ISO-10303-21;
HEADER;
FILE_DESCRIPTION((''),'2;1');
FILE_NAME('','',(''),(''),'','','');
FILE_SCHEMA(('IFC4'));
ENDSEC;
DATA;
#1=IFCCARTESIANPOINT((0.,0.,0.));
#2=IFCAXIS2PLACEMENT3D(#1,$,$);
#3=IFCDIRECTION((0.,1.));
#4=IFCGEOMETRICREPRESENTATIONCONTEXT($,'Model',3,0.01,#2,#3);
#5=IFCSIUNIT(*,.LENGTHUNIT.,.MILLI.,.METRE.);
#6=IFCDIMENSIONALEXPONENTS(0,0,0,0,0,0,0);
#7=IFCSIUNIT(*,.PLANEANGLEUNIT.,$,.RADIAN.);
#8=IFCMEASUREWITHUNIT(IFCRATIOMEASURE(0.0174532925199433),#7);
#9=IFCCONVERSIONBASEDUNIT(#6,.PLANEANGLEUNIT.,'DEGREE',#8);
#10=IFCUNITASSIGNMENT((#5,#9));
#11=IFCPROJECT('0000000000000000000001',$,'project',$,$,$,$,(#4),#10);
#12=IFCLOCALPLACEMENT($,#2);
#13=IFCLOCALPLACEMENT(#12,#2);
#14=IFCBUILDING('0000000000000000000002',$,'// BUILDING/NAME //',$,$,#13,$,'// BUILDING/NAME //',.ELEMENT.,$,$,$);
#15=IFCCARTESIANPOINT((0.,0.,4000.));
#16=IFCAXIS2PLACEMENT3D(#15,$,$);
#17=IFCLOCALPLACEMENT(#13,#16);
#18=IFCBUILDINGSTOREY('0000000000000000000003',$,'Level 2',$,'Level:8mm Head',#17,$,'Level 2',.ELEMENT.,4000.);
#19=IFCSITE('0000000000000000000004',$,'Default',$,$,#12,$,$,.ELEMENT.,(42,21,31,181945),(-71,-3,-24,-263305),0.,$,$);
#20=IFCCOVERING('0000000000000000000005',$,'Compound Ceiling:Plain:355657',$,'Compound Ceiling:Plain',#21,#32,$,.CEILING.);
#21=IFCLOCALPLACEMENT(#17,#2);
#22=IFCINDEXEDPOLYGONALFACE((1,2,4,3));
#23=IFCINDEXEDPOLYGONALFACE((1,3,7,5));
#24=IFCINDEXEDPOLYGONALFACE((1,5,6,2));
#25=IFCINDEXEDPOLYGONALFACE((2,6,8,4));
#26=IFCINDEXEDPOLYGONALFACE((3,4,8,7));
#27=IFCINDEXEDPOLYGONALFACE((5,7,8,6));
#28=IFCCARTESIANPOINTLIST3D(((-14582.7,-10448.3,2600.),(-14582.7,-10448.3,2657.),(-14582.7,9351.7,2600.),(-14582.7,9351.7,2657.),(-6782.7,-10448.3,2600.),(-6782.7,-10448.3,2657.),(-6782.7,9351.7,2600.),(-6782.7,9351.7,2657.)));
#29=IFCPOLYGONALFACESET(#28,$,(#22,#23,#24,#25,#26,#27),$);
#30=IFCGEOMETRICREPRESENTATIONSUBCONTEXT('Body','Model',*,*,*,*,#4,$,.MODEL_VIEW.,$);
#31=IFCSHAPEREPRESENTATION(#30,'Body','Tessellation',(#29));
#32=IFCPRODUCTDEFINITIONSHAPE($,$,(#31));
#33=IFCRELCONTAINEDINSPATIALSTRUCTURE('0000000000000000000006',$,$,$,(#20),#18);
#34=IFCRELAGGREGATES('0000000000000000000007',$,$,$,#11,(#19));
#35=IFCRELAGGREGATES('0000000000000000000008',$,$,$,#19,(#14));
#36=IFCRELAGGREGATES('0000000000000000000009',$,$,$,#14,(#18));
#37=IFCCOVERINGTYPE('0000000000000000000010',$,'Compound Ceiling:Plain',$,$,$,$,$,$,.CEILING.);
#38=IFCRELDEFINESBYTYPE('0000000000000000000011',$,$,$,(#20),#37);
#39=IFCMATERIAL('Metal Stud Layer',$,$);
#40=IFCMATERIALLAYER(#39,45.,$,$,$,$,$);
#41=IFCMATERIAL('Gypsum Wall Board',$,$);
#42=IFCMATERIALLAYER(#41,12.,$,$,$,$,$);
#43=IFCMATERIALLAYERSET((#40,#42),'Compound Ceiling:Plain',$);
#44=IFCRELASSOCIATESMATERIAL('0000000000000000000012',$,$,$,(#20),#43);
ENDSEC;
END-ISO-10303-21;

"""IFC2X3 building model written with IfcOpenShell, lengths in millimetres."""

from ifc_helpers import new_model, entity, si_unit, converted_unit, direction, frame, frame_2d, origin, place, context, subcontext, project, spatial, rectangle, extrude, material, layer, layer_set, layer_usage, type_object, element, save


model = new_model("IFC2X3")

# Units and contexts
model_context = context("Model", 3, precision=0.01, world=origin(), true_north=direction((0.0, 1.0)))
body_context = subcontext(model_context, "Body", "Model", "MODEL_VIEW")
ifc_project = project(units=[si_unit("LENGTHUNIT", "METRE", prefix="MILLI"), converted_unit("PLANEANGLEUNIT", "DEGREE", entity("IfcRatioMeasure", 0.0174532925199433), si_unit("PLANEANGLEUNIT", "RADIAN"), dimensions=[0, 0, 0, 0, 0, 0, 0])], contexts=[model_context])

# Site, building, storey
site_placement = place(None, origin())
site = spatial("IfcSite", under=ifc_project, at=site_placement, Name="Default", CompositionType="ELEMENT", RefLatitude=(42, 21, 31, 181945), RefLongitude=(-71, -3, -24, -263305), RefElevation=0.0)
building_placement = place(site_placement, origin())
building = spatial("IfcBuilding", under=site, at=building_placement, Name="// BUILDING/NAME //", LongName="// BUILDING/NAME //", CompositionType="ELEMENT")
storey_placement = place(building_placement, frame((0.0, 0.0, 4000.0)))
storey = spatial("IfcBuildingStorey", under=building, at=storey_placement, Name="Level 2", ObjectType="Level:8mm Head", LongName="Level 2", CompositionType="ELEMENT", Elevation=4000.0)

# Covering
ifc_material_1 = material(Name="Metal Stud Layer")
ifc_layer_1 = layer(ifc_material_1, 45.0)
ifc_material_2 = material(Name="Gypsum Wall Board")
ifc_layer_2 = layer(ifc_material_2, 12.0)
ifc_layer_set_1 = layer_set([ifc_layer_1, ifc_layer_2], Name="Compound Ceiling:Plain")
ifc_layer_usage_1 = layer_usage(ifc_layer_set_1, "AXIS3", "POSITIVE", 0.0)
covering_type = type_object("IfcCoveringType", Name="Compound Ceiling:Plain", PredefinedType="CEILING")
covering_placement = place(storey_placement, origin())
element("IfcCovering", 1, at=covering_placement, inside=storey, type_object=covering_type, material=ifc_layer_usage_1, Name="Compound Ceiling:Plain:355657", ObjectType="Compound Ceiling:Plain", PredefinedType="CEILING", context=body_context, shape_type="SweptSolid", body=[
    extrude(rectangle(XDim=7800.0, YDim=19800.0, at=frame_2d((0.0, 0.0), x_axis=(1.0, 0.0))), frame((-10682.7, -548.3, 2600.0), z_axis=(0.0, 0.0, 1.0), x_axis=(-1.0, 0.0, 0.0)), (0.0, 0.0, 1.0), 57.0),
])

save(model, "model.ifc")
